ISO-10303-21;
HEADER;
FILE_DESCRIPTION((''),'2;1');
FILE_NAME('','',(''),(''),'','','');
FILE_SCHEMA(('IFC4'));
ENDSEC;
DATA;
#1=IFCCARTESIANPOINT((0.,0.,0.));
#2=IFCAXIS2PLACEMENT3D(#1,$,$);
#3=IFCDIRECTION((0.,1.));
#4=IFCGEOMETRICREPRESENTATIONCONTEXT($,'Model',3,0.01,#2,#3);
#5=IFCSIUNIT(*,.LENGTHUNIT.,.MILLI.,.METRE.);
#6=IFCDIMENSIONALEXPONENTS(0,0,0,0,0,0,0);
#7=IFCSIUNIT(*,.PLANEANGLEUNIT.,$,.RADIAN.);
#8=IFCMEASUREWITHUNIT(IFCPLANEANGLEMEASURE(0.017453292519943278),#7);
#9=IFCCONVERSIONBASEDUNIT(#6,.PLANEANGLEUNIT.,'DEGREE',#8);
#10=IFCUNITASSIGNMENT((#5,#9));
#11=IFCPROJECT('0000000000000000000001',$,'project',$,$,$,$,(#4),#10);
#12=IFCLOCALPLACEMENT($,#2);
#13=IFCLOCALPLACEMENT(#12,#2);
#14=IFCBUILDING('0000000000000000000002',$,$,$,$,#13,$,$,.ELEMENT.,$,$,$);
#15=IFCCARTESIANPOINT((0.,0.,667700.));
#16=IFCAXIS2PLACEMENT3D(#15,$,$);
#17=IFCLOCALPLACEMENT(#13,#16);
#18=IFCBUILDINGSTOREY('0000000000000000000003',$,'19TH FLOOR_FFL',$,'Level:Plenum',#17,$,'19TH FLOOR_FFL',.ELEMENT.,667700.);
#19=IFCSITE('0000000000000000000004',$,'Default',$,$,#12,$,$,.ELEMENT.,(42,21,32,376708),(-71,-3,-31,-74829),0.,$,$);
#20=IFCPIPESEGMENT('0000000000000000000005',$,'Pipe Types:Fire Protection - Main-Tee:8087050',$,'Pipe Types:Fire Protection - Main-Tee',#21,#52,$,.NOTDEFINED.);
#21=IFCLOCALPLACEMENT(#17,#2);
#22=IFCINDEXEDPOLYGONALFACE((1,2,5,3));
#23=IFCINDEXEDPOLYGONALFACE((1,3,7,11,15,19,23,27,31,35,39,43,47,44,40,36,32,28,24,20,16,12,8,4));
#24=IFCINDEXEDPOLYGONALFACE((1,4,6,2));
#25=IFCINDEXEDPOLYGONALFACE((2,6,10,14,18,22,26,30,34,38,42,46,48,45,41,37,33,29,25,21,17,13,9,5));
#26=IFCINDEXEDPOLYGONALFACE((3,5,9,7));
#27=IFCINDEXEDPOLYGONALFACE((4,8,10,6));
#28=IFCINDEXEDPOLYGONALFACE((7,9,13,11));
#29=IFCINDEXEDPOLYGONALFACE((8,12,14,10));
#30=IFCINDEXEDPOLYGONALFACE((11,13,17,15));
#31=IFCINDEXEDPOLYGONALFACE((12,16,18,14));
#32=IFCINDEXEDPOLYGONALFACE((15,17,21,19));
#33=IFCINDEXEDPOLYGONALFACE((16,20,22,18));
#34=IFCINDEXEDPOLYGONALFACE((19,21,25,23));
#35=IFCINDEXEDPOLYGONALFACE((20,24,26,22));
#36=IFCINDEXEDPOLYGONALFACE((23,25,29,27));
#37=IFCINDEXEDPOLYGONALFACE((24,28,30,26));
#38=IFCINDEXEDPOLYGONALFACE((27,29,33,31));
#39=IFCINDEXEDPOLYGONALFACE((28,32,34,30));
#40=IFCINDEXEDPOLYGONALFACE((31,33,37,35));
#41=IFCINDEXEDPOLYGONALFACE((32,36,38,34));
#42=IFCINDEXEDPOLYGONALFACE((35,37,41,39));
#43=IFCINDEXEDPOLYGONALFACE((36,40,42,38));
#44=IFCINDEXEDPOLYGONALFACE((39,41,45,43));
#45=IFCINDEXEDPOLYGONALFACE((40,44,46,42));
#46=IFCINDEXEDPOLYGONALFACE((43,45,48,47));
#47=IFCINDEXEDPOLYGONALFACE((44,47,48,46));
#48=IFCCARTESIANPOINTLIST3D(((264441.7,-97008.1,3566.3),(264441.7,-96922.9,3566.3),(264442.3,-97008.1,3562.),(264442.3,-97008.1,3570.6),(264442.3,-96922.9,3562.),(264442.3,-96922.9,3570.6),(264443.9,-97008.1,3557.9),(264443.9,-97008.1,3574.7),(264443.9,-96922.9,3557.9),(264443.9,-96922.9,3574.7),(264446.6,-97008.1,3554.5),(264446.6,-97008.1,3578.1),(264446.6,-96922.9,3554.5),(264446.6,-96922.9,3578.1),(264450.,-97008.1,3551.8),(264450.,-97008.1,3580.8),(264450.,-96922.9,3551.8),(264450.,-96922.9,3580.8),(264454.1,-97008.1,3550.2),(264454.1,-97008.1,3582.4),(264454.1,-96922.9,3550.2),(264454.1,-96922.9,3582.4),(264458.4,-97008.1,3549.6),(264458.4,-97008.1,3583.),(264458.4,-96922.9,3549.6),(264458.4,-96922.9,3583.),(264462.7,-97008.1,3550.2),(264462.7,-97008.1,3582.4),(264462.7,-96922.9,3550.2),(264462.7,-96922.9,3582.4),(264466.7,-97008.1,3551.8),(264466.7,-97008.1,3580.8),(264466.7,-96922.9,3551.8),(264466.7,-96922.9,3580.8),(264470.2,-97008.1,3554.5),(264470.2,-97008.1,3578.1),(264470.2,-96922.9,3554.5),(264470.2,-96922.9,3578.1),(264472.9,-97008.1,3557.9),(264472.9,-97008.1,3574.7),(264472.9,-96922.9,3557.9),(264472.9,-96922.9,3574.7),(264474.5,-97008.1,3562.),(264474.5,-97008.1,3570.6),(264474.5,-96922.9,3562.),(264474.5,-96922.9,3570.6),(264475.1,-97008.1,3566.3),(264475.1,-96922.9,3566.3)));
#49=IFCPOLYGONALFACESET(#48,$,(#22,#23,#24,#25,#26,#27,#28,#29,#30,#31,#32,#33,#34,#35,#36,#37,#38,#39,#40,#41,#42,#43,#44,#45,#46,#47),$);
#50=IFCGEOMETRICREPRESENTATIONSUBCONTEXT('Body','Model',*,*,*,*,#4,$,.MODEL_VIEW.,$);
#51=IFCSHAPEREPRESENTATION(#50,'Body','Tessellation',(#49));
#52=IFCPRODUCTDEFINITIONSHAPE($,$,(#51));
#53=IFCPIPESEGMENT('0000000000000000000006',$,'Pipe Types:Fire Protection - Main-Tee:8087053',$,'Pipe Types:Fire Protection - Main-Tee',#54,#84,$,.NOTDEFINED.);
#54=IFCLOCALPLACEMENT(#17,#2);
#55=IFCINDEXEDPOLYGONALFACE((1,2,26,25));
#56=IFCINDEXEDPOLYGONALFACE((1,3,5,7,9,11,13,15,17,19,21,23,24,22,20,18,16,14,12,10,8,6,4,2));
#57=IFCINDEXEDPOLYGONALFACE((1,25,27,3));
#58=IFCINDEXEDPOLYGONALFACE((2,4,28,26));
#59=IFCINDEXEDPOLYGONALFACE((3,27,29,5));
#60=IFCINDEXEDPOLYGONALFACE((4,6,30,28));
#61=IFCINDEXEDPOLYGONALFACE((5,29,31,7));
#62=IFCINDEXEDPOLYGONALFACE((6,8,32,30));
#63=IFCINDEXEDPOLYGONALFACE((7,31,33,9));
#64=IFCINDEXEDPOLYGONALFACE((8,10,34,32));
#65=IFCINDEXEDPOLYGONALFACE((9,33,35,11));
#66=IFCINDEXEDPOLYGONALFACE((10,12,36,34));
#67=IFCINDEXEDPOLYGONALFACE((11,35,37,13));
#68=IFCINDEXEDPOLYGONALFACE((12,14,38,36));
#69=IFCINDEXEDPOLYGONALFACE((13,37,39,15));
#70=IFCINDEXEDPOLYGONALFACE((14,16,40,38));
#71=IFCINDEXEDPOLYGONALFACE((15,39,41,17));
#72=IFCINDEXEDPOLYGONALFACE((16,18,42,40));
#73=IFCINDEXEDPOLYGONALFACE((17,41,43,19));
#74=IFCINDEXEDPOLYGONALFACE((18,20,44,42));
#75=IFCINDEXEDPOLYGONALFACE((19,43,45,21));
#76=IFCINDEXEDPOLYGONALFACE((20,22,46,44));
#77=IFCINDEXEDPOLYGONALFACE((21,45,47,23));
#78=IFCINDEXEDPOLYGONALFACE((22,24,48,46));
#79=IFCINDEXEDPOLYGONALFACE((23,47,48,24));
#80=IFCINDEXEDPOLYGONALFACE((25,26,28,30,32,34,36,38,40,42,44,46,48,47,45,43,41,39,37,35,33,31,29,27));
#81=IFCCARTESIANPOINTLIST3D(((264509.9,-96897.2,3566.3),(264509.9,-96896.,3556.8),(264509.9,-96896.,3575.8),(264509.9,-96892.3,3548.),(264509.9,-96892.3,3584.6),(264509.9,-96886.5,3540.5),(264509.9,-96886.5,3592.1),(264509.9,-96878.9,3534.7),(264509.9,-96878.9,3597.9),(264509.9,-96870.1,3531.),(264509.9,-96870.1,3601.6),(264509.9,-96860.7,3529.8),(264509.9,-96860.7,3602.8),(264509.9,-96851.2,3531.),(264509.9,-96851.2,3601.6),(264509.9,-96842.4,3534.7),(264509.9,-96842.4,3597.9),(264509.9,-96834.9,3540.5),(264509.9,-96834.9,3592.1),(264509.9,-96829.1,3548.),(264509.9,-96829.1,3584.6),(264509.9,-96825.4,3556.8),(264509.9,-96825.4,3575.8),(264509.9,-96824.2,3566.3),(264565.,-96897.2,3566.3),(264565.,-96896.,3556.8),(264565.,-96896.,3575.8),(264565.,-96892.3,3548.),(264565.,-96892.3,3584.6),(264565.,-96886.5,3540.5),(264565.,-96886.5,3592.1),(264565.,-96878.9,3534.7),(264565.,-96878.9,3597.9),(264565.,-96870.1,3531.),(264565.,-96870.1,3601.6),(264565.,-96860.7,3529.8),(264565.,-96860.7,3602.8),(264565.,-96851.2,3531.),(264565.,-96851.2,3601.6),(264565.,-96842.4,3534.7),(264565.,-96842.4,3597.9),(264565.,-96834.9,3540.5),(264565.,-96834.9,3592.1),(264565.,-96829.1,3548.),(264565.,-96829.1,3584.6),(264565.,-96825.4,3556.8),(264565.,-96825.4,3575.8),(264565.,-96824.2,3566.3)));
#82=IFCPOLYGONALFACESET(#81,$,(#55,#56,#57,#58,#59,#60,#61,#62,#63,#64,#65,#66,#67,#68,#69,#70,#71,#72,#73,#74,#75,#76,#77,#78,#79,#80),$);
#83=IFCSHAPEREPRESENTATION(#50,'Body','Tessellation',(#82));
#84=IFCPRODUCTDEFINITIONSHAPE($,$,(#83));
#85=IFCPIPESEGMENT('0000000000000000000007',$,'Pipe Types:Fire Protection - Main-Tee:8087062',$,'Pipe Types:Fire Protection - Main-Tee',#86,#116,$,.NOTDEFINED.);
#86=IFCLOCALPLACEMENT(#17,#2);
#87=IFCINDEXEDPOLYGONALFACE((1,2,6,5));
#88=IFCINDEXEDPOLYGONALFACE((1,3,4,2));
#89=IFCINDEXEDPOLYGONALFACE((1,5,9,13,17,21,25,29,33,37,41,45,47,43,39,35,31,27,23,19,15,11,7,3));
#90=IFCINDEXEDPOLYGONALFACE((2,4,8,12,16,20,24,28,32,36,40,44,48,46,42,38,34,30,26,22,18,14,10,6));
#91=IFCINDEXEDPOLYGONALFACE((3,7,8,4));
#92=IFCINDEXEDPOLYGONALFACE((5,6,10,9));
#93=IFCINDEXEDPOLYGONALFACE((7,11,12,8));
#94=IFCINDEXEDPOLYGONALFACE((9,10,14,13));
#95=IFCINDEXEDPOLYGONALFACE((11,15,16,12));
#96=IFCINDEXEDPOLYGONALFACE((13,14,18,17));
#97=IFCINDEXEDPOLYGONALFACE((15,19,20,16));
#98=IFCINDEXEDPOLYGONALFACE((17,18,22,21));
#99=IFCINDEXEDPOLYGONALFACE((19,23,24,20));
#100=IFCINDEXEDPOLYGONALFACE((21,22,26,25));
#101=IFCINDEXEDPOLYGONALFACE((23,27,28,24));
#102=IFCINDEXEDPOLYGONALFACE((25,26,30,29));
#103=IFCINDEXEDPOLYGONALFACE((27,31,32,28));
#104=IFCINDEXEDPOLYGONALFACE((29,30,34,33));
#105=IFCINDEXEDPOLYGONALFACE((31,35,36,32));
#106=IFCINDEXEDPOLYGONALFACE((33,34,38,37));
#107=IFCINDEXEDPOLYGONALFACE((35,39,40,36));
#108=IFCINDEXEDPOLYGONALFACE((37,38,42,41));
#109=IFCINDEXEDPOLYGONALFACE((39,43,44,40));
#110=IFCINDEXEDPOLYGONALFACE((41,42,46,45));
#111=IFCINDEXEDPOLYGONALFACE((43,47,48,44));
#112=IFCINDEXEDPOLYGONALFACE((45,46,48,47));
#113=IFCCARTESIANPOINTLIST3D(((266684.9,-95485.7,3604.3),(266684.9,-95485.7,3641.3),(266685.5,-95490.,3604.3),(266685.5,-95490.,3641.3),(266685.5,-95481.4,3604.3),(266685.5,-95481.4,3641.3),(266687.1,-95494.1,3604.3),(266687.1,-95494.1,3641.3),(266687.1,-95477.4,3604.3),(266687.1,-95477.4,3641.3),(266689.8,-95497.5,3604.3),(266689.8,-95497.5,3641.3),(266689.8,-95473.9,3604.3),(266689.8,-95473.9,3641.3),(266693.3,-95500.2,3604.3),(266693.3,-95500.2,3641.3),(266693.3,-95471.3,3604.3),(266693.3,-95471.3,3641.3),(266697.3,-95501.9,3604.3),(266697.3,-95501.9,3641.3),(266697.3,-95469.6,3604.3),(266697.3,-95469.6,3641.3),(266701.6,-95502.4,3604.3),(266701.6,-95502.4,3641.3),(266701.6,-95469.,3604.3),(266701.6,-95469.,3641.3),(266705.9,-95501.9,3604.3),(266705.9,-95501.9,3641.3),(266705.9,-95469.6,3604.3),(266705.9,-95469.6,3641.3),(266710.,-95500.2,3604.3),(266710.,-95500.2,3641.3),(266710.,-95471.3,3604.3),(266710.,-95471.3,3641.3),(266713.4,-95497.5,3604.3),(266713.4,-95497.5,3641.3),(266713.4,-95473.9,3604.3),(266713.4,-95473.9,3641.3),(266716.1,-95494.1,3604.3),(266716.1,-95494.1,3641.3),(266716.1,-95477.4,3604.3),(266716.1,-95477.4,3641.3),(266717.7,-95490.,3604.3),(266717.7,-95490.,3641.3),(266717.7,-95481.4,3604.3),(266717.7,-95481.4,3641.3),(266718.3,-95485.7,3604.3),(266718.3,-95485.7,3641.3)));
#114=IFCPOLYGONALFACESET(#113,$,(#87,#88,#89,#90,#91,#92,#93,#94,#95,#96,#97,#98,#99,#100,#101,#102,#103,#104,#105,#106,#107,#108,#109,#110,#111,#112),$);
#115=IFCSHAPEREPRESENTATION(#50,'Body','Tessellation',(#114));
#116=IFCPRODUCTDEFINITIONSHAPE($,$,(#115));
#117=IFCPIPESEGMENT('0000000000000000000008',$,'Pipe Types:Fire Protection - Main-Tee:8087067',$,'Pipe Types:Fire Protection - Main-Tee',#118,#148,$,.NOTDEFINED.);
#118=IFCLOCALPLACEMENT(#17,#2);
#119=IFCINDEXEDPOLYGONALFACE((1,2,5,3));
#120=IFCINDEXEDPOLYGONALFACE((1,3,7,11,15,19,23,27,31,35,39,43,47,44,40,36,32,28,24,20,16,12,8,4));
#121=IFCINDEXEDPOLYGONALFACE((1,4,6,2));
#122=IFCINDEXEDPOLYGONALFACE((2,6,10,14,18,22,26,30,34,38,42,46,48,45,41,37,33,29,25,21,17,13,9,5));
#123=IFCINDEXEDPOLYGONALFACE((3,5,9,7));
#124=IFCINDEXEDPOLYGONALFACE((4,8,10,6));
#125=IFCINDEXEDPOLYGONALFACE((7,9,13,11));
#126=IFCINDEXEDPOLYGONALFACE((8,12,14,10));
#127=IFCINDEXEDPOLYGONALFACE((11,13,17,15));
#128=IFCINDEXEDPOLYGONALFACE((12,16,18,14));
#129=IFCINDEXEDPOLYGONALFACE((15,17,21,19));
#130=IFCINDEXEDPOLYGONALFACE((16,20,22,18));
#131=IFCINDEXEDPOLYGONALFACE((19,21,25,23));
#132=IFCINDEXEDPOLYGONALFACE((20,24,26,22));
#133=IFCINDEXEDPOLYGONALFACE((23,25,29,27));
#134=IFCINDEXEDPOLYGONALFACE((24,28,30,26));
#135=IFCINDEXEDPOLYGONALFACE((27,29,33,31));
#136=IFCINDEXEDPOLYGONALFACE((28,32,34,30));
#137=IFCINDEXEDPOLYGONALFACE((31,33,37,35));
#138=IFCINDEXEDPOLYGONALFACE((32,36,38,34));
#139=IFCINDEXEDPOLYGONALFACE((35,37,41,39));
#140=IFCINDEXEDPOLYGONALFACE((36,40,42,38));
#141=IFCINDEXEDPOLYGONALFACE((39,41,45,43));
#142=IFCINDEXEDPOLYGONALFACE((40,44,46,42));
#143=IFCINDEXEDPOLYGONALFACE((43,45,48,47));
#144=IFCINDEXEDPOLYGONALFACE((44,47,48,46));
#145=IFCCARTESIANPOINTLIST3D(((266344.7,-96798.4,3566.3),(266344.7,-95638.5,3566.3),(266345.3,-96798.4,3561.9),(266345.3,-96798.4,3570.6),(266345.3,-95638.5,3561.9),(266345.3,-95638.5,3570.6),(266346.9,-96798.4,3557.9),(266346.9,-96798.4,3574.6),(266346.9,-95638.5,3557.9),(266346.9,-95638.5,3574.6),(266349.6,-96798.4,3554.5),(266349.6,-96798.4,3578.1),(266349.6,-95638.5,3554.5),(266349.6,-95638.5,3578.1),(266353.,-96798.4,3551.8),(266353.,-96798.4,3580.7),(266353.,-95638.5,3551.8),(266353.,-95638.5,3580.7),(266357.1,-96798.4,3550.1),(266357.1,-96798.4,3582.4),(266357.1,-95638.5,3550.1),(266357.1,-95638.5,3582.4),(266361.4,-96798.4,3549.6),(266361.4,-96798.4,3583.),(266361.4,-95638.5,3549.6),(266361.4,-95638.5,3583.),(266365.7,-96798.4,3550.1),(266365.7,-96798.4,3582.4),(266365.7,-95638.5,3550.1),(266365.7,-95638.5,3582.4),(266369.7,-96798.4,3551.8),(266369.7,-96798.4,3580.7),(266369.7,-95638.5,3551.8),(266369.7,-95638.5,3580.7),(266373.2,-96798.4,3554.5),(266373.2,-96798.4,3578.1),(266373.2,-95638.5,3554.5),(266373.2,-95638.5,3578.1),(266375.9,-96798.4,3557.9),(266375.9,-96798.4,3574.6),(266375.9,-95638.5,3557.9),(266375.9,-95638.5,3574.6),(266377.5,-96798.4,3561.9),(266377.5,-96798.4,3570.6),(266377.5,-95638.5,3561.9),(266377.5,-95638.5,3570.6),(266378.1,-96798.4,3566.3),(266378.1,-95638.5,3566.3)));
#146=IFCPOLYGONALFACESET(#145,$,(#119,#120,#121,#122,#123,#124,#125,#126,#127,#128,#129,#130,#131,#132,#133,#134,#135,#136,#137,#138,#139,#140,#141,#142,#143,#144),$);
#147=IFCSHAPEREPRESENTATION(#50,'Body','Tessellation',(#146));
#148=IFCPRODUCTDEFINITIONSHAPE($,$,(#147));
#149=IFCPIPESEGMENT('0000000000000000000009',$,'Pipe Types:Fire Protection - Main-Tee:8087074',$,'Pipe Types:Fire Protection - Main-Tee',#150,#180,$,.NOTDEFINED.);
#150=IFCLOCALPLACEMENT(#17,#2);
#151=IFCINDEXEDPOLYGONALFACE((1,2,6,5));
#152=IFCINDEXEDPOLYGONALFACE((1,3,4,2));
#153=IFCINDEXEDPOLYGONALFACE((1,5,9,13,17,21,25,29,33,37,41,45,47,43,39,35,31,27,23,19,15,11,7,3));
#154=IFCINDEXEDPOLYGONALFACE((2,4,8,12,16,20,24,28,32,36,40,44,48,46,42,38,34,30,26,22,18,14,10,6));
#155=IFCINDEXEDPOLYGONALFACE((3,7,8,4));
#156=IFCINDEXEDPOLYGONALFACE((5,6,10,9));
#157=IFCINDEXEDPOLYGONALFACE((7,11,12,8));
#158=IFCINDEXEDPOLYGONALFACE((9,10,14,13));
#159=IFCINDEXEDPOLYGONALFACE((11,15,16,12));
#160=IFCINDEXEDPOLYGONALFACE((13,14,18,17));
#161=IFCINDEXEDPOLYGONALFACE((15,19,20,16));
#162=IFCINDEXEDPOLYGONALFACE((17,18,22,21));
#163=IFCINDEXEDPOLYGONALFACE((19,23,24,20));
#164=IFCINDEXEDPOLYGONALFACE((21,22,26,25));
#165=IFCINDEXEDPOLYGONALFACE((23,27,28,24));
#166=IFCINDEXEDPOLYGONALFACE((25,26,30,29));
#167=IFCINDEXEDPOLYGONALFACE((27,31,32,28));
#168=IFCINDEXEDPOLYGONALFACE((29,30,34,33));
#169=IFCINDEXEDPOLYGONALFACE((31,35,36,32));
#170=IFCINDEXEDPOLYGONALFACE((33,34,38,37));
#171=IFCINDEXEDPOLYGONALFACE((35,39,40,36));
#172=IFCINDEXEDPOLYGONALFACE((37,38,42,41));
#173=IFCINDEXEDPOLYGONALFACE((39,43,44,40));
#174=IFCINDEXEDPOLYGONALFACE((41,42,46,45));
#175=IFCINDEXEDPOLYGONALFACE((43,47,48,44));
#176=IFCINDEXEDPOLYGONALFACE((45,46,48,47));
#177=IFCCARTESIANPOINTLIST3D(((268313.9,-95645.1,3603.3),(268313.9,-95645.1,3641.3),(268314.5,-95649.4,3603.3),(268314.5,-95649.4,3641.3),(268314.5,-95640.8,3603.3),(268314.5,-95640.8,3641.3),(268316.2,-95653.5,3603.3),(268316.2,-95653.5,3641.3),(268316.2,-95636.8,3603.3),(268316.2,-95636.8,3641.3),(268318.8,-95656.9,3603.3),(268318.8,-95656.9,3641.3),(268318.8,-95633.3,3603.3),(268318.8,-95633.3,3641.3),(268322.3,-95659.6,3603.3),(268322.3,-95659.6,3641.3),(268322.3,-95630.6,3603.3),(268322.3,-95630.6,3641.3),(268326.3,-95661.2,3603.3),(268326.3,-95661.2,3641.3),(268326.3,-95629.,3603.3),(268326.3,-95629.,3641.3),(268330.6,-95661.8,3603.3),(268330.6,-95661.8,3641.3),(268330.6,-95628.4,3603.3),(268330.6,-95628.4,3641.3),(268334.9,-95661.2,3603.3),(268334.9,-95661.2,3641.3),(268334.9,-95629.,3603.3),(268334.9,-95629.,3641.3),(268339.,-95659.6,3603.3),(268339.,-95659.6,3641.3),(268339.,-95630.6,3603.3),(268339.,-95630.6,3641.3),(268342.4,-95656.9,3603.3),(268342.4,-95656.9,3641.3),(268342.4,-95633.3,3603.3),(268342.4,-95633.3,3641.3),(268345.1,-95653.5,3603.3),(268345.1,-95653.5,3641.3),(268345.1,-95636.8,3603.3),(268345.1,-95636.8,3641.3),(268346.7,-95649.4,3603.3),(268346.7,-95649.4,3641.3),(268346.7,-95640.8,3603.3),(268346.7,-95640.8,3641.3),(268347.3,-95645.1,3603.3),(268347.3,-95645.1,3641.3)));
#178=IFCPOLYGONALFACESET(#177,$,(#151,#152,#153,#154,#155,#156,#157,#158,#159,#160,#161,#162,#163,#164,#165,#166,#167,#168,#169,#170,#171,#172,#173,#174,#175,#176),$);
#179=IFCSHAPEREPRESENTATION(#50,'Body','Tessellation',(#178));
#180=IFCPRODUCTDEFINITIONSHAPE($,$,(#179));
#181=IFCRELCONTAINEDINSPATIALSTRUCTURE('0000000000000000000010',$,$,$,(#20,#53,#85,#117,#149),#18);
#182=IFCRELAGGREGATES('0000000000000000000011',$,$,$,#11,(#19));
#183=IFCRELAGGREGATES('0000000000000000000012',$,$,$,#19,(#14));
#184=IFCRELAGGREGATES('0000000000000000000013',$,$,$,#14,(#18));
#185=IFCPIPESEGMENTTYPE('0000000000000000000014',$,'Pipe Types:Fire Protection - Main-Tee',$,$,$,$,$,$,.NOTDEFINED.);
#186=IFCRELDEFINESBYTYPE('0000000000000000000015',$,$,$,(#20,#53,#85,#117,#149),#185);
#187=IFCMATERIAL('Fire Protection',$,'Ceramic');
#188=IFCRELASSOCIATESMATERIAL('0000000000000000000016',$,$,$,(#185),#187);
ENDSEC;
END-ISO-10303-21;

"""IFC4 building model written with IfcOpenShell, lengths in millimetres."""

from ifc_helpers import new_model, entity, si_unit, converted_unit, direction, frame, origin, place, context, subcontext, project, spatial, arc, indexed_curve, outline, extrude, material, type_object, element, save


model = new_model("IFC4")

# Units and contexts
model_context = context("Model", 3, precision=0.01, world=origin(), true_north=direction((0.0, 1.0)))
body_context = subcontext(model_context, "Body", "Model", "MODEL_VIEW")
ifc_project = project(units=[si_unit("LENGTHUNIT", "METRE", prefix="MILLI"), converted_unit("PLANEANGLEUNIT", "DEGREE", entity("IfcPlaneAngleMeasure", 0.017453292519943278), si_unit("PLANEANGLEUNIT", "RADIAN"), dimensions=[0, 0, 0, 0, 0, 0, 0])], contexts=[model_context])

# Site, building, storey
site_placement = place(None, origin())
site = spatial("IfcSite", under=ifc_project, at=site_placement, Name="Default", CompositionType="ELEMENT", RefLatitude=(42, 21, 32, 376708), RefLongitude=(-71, -3, -31, -74829), RefElevation=0.0)
building_placement = place(site_placement, origin())
building = spatial("IfcBuilding", under=site, at=building_placement, CompositionType="ELEMENT")
storey_placement = place(building_placement, frame((0.0, 0.0, 667700.0)))
storey = spatial("IfcBuildingStorey", under=building, at=storey_placement, Name="19TH FLOOR_FFL", ObjectType="Level:Plenum", LongName="19TH FLOOR_FFL", CompositionType="ELEMENT", Elevation=667700.0)

# Pipe segments
ifc_material = material(Name="Fire Protection", Category="Ceramic")
pipe_segment_type = type_object("IfcPipeSegmentType", Name="Pipe Types:Fire Protection - Main-Tee", PredefinedType="NOTDEFINED", material=ifc_material)
pipe_segment_1_placement = place(storey_placement, origin())
element("IfcPipeSegment", 1, at=pipe_segment_1_placement, inside=storey, type_object=pipe_segment_type, Name="Pipe Types:Fire Protection - Main-Tee:8087050", ObjectType="Pipe Types:Fire Protection - Main-Tee", PredefinedType="NOTDEFINED", context=body_context, shape_type="SweptSolid", body=[
    extrude(outline(indexed_curve([(16.7, 0.0), (11.8, 11.8), (0.0, 16.7), (-11.8, 11.8), (-16.7, 0.0), (-11.8, -11.8), (0.0, -16.7), (11.8, -11.8)], segments=[arc(1, 2, 3), arc(3, 4, 5), arc(5, 6, 7), arc(7, 8, 1)], self_intersect=False)), frame((264458.4, -97008.1, 3566.3), z_axis=(0.0, 1.0, 0.0), x_axis=(-1.0, 0.0, 0.0)), (0.0, 0.0, 1.0), 85.2),
])
pipe_segment_2_placement = place(storey_placement, origin())
element("IfcPipeSegment", 2, at=pipe_segment_2_placement, inside=storey, type_object=pipe_segment_type, Name="Pipe Types:Fire Protection - Main-Tee:8087053", ObjectType="Pipe Types:Fire Protection - Main-Tee", PredefinedType="NOTDEFINED", context=body_context, shape_type="SweptSolid", body=[
    extrude(outline(indexed_curve([(36.5, 0.0), (25.8, 25.8), (0.0, 36.5), (-25.8, 25.8), (-36.5, 0.0), (-25.8, -25.8), (0.0, -36.5), (25.8, -25.8)], segments=[arc(1, 2, 3), arc(3, 4, 5), arc(5, 6, 7), arc(7, 8, 1)], self_intersect=False)), frame((264509.9, -96860.7, 3566.3), z_axis=(1.0, 0.0, 0.0), x_axis=(0.0, 1.0, 0.0)), (0.0, 0.0, 1.0), 55.0),
])
pipe_segment_3_placement = place(storey_placement, origin())
element("IfcPipeSegment", 3, at=pipe_segment_3_placement, inside=storey, type_object=pipe_segment_type, Name="Pipe Types:Fire Protection - Main-Tee:8087062", ObjectType="Pipe Types:Fire Protection - Main-Tee", PredefinedType="NOTDEFINED", context=body_context, shape_type="SweptSolid", body=[
    extrude(outline(indexed_curve([(16.7, 0.0), (11.8, 11.8), (0.0, 16.7), (-11.8, 11.8), (-16.7, 0.0), (-11.8, -11.8), (0.0, -16.7), (11.8, -11.8)], segments=[arc(1, 2, 3), arc(3, 4, 5), arc(5, 6, 7), arc(7, 8, 1)], self_intersect=False)), frame((266701.6, -95485.7, 3604.3)), (0.0, 0.0, 1.0), 37.0),
])
pipe_segment_4_placement = place(storey_placement, origin())
element("IfcPipeSegment", 4, at=pipe_segment_4_placement, inside=storey, type_object=pipe_segment_type, Name="Pipe Types:Fire Protection - Main-Tee:8087067", ObjectType="Pipe Types:Fire Protection - Main-Tee", PredefinedType="NOTDEFINED", context=body_context, shape_type="SweptSolid", body=[
    extrude(outline(indexed_curve([(16.7, 0.0), (11.8, 11.8), (0.0, 16.7), (-11.8, 11.8), (-16.7, 0.0), (-11.8, -11.8), (0.0, -16.7), (11.8, -11.8)], segments=[arc(1, 2, 3), arc(3, 4, 5), arc(5, 6, 7), arc(7, 8, 1)], self_intersect=False)), frame((266361.4, -96798.4, 3566.3), z_axis=(0.0, 1.0, 0.0), x_axis=(1.0, 0.0, 0.0)), (0.0, 0.0, 1.0), 1160.0),
])
pipe_segment_5_placement = place(storey_placement, origin())
element("IfcPipeSegment", 5, at=pipe_segment_5_placement, inside=storey, type_object=pipe_segment_type, Name="Pipe Types:Fire Protection - Main-Tee:8087074", ObjectType="Pipe Types:Fire Protection - Main-Tee", PredefinedType="NOTDEFINED", context=body_context, shape_type="SweptSolid", body=[
    extrude(outline(indexed_curve([(16.7, 0.0), (11.8, 11.8), (0.0, 16.7), (-11.8, 11.8), (-16.7, 0.0), (-11.8, -11.8), (0.0, -16.7), (11.8, -11.8)], segments=[arc(1, 2, 3), arc(3, 4, 5), arc(5, 6, 7), arc(7, 8, 1)], self_intersect=False)), frame((268330.6, -95645.1, 3603.3)), (0.0, 0.0, 1.0), 38.0),
])

save(model, "model.ifc")
